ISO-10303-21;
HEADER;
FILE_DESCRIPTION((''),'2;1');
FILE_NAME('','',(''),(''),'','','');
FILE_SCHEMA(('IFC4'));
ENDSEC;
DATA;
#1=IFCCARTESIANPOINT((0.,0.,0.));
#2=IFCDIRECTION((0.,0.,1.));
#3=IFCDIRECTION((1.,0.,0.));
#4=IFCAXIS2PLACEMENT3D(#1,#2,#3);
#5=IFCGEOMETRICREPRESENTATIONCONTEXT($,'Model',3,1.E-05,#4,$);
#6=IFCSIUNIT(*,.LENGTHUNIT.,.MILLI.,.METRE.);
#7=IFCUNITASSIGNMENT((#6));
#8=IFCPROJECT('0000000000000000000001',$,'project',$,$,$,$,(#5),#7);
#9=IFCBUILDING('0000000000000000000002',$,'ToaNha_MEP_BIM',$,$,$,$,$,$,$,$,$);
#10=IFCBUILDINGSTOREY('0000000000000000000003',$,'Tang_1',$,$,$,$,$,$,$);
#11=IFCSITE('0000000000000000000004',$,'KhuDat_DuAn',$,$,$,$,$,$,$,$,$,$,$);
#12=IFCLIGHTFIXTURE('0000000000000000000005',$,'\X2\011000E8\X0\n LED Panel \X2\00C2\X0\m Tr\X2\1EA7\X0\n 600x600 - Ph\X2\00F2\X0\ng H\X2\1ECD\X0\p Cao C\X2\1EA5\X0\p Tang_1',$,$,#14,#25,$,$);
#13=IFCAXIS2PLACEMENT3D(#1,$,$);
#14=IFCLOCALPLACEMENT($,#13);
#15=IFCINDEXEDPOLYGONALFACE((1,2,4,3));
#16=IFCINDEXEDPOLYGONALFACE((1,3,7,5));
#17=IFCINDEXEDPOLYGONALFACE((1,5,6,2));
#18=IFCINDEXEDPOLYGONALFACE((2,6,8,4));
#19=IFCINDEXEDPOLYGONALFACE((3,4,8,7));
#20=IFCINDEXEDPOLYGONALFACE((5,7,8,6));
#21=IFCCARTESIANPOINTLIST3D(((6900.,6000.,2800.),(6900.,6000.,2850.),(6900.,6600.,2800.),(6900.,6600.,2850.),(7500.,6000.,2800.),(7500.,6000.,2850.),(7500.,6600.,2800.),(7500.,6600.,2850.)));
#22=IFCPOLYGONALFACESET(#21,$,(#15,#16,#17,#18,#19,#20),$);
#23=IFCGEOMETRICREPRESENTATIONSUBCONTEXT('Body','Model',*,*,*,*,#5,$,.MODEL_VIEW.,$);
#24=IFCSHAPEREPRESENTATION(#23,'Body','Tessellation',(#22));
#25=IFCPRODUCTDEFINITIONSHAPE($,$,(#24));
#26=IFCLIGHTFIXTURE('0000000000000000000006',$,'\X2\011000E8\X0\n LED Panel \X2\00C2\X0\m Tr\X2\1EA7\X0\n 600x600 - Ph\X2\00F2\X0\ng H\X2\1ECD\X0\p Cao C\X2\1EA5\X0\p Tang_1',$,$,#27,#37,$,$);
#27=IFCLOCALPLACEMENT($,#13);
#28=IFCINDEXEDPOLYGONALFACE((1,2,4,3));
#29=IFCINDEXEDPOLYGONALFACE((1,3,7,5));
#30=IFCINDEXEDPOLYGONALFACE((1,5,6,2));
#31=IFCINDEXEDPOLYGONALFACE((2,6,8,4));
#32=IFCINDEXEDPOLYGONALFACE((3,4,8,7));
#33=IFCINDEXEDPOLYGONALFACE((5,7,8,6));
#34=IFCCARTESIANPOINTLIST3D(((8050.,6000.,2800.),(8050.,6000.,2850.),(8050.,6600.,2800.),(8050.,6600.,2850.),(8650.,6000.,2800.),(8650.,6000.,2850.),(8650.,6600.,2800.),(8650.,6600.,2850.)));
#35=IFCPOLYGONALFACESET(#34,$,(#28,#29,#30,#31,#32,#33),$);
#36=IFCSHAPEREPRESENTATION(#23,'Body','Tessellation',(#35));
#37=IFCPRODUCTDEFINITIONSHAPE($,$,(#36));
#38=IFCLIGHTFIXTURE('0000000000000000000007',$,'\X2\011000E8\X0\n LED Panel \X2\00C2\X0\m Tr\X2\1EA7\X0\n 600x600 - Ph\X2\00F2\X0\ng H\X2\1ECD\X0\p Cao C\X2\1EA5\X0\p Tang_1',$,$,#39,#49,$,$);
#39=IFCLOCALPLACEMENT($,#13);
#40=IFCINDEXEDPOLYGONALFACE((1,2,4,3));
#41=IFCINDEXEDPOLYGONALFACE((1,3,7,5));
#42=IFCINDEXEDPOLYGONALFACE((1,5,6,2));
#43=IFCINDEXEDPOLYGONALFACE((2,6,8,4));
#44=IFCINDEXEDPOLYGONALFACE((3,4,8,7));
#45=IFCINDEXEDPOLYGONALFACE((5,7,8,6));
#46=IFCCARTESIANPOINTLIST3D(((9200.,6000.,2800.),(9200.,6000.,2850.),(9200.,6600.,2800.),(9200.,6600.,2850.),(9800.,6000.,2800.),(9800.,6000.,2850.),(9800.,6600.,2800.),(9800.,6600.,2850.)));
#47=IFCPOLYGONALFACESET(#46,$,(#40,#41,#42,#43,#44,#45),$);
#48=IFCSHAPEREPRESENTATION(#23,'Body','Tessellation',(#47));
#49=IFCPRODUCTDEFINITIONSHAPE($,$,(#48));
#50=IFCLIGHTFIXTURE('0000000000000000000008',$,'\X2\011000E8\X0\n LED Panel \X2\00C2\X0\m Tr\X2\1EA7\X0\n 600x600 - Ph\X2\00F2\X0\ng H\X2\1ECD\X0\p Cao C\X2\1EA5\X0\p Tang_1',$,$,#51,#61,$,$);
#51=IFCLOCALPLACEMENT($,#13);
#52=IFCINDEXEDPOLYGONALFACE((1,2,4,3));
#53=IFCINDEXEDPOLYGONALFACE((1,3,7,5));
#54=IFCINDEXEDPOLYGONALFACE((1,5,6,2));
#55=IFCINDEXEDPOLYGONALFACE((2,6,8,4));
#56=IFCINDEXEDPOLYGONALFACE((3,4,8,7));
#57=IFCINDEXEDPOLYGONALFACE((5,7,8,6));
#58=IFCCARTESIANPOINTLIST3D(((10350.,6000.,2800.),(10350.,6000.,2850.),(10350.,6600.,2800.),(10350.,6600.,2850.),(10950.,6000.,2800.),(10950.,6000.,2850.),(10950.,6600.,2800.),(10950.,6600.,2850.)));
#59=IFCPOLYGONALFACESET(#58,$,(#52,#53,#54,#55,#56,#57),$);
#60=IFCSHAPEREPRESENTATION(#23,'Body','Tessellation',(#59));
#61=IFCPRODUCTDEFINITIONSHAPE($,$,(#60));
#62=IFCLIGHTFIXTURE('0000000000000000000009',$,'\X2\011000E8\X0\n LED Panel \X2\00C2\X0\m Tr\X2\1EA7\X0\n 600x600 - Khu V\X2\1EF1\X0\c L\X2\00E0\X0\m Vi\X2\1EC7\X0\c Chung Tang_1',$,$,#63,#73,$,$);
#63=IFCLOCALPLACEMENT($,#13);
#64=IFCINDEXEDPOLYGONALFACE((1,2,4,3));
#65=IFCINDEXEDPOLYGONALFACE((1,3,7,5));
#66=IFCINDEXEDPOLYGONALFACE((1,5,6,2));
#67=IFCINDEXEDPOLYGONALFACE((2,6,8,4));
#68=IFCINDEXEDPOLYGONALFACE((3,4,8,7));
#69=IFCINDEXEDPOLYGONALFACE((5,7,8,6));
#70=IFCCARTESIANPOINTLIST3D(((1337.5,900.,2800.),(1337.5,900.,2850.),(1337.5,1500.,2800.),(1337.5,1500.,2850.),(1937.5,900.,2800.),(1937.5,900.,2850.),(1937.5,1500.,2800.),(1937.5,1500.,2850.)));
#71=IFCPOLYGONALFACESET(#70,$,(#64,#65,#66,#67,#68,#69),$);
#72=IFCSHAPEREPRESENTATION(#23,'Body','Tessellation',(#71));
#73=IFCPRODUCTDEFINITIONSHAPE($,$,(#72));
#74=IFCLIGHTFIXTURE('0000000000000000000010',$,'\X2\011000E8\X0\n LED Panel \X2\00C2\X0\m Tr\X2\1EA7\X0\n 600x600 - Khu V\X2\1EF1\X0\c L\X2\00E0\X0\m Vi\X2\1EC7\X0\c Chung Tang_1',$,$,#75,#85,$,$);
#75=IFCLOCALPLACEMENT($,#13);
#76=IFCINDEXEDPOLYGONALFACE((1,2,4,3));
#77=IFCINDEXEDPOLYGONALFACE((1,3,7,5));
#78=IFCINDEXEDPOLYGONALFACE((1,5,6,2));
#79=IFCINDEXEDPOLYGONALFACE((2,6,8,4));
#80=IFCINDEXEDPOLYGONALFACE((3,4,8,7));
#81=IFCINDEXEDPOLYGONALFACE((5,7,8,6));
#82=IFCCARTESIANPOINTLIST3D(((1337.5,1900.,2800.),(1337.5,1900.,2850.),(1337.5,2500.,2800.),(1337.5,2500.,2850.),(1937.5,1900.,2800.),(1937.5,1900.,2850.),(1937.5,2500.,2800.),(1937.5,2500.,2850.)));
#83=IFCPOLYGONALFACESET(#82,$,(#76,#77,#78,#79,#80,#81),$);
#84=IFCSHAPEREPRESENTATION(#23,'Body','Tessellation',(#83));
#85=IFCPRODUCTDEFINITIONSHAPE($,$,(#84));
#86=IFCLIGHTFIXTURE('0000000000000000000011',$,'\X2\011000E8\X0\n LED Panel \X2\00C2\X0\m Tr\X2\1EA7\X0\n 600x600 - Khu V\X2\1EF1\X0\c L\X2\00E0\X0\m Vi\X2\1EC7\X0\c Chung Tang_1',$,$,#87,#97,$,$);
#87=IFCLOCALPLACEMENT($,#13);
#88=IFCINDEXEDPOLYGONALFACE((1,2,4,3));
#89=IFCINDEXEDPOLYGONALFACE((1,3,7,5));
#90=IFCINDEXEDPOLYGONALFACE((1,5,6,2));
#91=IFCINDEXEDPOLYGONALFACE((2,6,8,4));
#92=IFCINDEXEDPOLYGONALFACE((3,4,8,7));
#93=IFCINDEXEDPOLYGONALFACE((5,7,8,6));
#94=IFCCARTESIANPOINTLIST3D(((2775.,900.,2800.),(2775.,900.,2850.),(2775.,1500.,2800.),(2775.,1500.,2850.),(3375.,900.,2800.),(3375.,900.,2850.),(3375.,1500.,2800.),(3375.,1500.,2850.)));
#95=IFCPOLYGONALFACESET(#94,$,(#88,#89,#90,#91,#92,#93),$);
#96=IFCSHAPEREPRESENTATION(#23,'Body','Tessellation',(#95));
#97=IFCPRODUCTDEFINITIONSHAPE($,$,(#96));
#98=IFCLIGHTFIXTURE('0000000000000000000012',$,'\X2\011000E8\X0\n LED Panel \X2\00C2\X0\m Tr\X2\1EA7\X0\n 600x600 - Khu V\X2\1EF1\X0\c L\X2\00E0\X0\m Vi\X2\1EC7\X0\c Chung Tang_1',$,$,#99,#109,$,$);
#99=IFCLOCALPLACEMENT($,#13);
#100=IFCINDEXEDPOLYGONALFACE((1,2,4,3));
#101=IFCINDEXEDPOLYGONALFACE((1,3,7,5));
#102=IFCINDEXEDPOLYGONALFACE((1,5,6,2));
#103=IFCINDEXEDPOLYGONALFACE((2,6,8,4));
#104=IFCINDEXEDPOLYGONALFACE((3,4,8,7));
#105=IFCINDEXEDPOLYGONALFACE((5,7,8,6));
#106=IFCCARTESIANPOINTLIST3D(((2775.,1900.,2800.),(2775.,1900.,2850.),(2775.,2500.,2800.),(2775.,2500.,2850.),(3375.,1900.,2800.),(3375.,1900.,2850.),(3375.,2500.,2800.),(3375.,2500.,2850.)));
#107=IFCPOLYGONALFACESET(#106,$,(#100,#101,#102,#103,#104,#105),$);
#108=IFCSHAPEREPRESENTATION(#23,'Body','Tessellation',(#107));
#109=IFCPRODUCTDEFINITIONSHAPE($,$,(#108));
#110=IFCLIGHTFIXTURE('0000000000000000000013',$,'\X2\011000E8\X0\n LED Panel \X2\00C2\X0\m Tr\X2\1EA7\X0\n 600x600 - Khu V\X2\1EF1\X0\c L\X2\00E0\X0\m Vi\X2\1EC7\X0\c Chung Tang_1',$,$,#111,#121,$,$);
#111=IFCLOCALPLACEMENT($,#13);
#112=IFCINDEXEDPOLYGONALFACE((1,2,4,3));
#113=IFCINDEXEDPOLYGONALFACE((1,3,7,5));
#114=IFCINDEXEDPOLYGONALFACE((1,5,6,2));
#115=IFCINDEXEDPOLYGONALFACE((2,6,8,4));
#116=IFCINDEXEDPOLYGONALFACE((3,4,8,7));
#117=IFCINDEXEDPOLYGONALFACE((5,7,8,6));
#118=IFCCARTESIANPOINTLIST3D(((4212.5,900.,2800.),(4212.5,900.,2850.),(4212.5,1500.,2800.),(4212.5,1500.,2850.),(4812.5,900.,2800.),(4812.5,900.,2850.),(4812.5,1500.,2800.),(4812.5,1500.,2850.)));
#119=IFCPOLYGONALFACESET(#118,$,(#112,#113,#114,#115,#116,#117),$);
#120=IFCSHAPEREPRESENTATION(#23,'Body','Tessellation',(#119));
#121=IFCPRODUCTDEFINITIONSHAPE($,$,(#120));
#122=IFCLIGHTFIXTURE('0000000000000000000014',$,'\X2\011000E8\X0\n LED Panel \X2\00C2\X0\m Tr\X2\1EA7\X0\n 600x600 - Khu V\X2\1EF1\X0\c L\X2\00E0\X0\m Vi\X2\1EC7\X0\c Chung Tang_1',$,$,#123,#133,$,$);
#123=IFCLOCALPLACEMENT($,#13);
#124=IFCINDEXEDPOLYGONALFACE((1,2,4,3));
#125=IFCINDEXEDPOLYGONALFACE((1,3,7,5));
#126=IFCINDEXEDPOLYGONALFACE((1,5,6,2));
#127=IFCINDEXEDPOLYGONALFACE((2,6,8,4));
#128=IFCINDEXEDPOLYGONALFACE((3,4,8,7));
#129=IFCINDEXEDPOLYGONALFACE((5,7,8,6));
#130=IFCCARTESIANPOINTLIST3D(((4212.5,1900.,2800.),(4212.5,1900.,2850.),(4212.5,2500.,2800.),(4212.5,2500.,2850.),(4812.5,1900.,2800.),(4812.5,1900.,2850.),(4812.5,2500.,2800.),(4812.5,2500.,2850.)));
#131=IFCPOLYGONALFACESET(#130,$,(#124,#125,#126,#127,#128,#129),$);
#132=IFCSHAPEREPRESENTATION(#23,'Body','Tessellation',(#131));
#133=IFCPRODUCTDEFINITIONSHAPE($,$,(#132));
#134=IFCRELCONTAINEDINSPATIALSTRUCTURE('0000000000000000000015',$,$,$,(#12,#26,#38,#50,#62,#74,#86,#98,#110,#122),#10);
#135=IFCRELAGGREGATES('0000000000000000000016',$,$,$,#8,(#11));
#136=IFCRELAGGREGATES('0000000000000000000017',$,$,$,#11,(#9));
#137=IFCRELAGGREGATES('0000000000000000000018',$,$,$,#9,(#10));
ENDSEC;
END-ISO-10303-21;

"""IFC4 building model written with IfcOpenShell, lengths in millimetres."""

from ifc_helpers import new_model, si_unit, frame, origin_with_axes, context, subcontext, project, spatial, polyline, outline, extrude, element, save


model = new_model("IFC4")

# Units and contexts
model_context = context("Model", 3, precision=1e-05, world=origin_with_axes())
body_context = subcontext(model_context, "Body", "Model", "MODEL_VIEW")
ifc_project = project(units=[si_unit("LENGTHUNIT", "METRE", prefix="MILLI")], contexts=[model_context])

# Site, building, storey
site = spatial("IfcSite", under=ifc_project, Name="KhuDat_DuAn")
building = spatial("IfcBuilding", under=site, Name="ToaNha_MEP_BIM")
storey = spatial("IfcBuildingStorey", under=building, Name="Tang_1")

# Light fixtures
element("IfcLightFixture", 1, inside=storey, Name="Đèn LED Panel Âm Trần 600x600 - Phòng Họp Cao Cấp Tang_1", context=body_context, shape_type="SweptSolid", body=[
    extrude(outline(polyline([(6900.0, 6000.0), (7500.0, 6000.0), (7500.0, 6600.0), (6900.0, 6600.0), (6900.0, 6000.0)])), frame((0.0, 0.0, 2800.0), z_axis=(0.0, 0.0, 1.0), x_axis=(1.0, 0.0, 0.0)), (0.0, 0.0, 1.0), 50.0),
])
element("IfcLightFixture", 2, inside=storey, Name="Đèn LED Panel Âm Trần 600x600 - Phòng Họp Cao Cấp Tang_1", context=body_context, shape_type="SweptSolid", body=[
    extrude(outline(polyline([(8050.0, 6000.0), (8650.0, 6000.0), (8650.0, 6600.0), (8050.0, 6600.0), (8050.0, 6000.0)])), frame((0.0, 0.0, 2800.0), z_axis=(0.0, 0.0, 1.0), x_axis=(1.0, 0.0, 0.0)), (0.0, 0.0, 1.0), 50.0),
])
element("IfcLightFixture", 3, inside=storey, Name="Đèn LED Panel Âm Trần 600x600 - Phòng Họp Cao Cấp Tang_1", context=body_context, shape_type="SweptSolid", body=[
    extrude(outline(polyline([(9200.0, 6000.0), (9800.0, 6000.0), (9800.0, 6600.0), (9200.0, 6600.0), (9200.0, 6000.0)])), frame((0.0, 0.0, 2800.0), z_axis=(0.0, 0.0, 1.0), x_axis=(1.0, 0.0, 0.0)), (0.0, 0.0, 1.0), 50.0),
])
element("IfcLightFixture", 4, inside=storey, Name="Đèn LED Panel Âm Trần 600x600 - Phòng Họp Cao Cấp Tang_1", context=body_context, shape_type="SweptSolid", body=[
    extrude(outline(polyline([(10350.0, 6000.0), (10950.0, 6000.0), (10950.0, 6600.0), (10350.0, 6600.0), (10350.0, 6000.0)])), frame((0.0, 0.0, 2800.0), z_axis=(0.0, 0.0, 1.0), x_axis=(1.0, 0.0, 0.0)), (0.0, 0.0, 1.0), 50.0),
])
element("IfcLightFixture", 5, inside=storey, Name="Đèn LED Panel Âm Trần 600x600 - Khu Vực Làm Việc Chung Tang_1", context=body_context, shape_type="SweptSolid", body=[
    extrude(outline(polyline([(1337.5, 900.0), (1937.5, 900.0), (1937.5, 1500.0), (1337.5, 1500.0), (1337.5, 900.0)])), frame((0.0, 0.0, 2800.0), z_axis=(0.0, 0.0, 1.0), x_axis=(1.0, 0.0, 0.0)), (0.0, 0.0, 1.0), 50.0),
])
element("IfcLightFixture", 6, inside=storey, Name="Đèn LED Panel Âm Trần 600x600 - Khu Vực Làm Việc Chung Tang_1", context=body_context, shape_type="SweptSolid", body=[
    extrude(outline(polyline([(1337.5, 1900.0), (1937.5, 1900.0), (1937.5, 2500.0), (1337.5, 2500.0), (1337.5, 1900.0)])), frame((0.0, 0.0, 2800.0), z_axis=(0.0, 0.0, 1.0), x_axis=(1.0, 0.0, 0.0)), (0.0, 0.0, 1.0), 50.0),
])
element("IfcLightFixture", 7, inside=storey, Name="Đèn LED Panel Âm Trần 600x600 - Khu Vực Làm Việc Chung Tang_1", context=body_context, shape_type="SweptSolid", body=[
    extrude(outline(polyline([(2775.0, 900.0), (3375.0, 900.0), (3375.0, 1500.0), (2775.0, 1500.0), (2775.0, 900.0)])), frame((0.0, 0.0, 2800.0), z_axis=(0.0, 0.0, 1.0), x_axis=(1.0, 0.0, 0.0)), (0.0, 0.0, 1.0), 50.0),
])
element("IfcLightFixture", 8, inside=storey, Name="Đèn LED Panel Âm Trần 600x600 - Khu Vực Làm Việc Chung Tang_1", context=body_context, shape_type="SweptSolid", body=[
    extrude(outline(polyline([(2775.0, 1900.0), (3375.0, 1900.0), (3375.0, 2500.0), (2775.0, 2500.0), (2775.0, 1900.0)])), frame((0.0, 0.0, 2800.0), z_axis=(0.0, 0.0, 1.0), x_axis=(1.0, 0.0, 0.0)), (0.0, 0.0, 1.0), 50.0),
])
element("IfcLightFixture", 9, inside=storey, Name="Đèn LED Panel Âm Trần 600x600 - Khu Vực Làm Việc Chung Tang_1", context=body_context, shape_type="SweptSolid", body=[
    extrude(outline(polyline([(4212.5, 900.0), (4812.5, 900.0), (4812.5, 1500.0), (4212.5, 1500.0), (4212.5, 900.0)])), frame((0.0, 0.0, 2800.0), z_axis=(0.0, 0.0, 1.0), x_axis=(1.0, 0.0, 0.0)), (0.0, 0.0, 1.0), 50.0),
])
element("IfcLightFixture", 10, inside=storey, Name="Đèn LED Panel Âm Trần 600x600 - Khu Vực Làm Việc Chung Tang_1", context=body_context, shape_type="SweptSolid", body=[
    extrude(outline(polyline([(4212.5, 1900.0), (4812.5, 1900.0), (4812.5, 2500.0), (4212.5, 2500.0), (4212.5, 1900.0)])), frame((0.0, 0.0, 2800.0), z_axis=(0.0, 0.0, 1.0), x_axis=(1.0, 0.0, 0.0)), (0.0, 0.0, 1.0), 50.0),
])

save(model, "model.ifc")
